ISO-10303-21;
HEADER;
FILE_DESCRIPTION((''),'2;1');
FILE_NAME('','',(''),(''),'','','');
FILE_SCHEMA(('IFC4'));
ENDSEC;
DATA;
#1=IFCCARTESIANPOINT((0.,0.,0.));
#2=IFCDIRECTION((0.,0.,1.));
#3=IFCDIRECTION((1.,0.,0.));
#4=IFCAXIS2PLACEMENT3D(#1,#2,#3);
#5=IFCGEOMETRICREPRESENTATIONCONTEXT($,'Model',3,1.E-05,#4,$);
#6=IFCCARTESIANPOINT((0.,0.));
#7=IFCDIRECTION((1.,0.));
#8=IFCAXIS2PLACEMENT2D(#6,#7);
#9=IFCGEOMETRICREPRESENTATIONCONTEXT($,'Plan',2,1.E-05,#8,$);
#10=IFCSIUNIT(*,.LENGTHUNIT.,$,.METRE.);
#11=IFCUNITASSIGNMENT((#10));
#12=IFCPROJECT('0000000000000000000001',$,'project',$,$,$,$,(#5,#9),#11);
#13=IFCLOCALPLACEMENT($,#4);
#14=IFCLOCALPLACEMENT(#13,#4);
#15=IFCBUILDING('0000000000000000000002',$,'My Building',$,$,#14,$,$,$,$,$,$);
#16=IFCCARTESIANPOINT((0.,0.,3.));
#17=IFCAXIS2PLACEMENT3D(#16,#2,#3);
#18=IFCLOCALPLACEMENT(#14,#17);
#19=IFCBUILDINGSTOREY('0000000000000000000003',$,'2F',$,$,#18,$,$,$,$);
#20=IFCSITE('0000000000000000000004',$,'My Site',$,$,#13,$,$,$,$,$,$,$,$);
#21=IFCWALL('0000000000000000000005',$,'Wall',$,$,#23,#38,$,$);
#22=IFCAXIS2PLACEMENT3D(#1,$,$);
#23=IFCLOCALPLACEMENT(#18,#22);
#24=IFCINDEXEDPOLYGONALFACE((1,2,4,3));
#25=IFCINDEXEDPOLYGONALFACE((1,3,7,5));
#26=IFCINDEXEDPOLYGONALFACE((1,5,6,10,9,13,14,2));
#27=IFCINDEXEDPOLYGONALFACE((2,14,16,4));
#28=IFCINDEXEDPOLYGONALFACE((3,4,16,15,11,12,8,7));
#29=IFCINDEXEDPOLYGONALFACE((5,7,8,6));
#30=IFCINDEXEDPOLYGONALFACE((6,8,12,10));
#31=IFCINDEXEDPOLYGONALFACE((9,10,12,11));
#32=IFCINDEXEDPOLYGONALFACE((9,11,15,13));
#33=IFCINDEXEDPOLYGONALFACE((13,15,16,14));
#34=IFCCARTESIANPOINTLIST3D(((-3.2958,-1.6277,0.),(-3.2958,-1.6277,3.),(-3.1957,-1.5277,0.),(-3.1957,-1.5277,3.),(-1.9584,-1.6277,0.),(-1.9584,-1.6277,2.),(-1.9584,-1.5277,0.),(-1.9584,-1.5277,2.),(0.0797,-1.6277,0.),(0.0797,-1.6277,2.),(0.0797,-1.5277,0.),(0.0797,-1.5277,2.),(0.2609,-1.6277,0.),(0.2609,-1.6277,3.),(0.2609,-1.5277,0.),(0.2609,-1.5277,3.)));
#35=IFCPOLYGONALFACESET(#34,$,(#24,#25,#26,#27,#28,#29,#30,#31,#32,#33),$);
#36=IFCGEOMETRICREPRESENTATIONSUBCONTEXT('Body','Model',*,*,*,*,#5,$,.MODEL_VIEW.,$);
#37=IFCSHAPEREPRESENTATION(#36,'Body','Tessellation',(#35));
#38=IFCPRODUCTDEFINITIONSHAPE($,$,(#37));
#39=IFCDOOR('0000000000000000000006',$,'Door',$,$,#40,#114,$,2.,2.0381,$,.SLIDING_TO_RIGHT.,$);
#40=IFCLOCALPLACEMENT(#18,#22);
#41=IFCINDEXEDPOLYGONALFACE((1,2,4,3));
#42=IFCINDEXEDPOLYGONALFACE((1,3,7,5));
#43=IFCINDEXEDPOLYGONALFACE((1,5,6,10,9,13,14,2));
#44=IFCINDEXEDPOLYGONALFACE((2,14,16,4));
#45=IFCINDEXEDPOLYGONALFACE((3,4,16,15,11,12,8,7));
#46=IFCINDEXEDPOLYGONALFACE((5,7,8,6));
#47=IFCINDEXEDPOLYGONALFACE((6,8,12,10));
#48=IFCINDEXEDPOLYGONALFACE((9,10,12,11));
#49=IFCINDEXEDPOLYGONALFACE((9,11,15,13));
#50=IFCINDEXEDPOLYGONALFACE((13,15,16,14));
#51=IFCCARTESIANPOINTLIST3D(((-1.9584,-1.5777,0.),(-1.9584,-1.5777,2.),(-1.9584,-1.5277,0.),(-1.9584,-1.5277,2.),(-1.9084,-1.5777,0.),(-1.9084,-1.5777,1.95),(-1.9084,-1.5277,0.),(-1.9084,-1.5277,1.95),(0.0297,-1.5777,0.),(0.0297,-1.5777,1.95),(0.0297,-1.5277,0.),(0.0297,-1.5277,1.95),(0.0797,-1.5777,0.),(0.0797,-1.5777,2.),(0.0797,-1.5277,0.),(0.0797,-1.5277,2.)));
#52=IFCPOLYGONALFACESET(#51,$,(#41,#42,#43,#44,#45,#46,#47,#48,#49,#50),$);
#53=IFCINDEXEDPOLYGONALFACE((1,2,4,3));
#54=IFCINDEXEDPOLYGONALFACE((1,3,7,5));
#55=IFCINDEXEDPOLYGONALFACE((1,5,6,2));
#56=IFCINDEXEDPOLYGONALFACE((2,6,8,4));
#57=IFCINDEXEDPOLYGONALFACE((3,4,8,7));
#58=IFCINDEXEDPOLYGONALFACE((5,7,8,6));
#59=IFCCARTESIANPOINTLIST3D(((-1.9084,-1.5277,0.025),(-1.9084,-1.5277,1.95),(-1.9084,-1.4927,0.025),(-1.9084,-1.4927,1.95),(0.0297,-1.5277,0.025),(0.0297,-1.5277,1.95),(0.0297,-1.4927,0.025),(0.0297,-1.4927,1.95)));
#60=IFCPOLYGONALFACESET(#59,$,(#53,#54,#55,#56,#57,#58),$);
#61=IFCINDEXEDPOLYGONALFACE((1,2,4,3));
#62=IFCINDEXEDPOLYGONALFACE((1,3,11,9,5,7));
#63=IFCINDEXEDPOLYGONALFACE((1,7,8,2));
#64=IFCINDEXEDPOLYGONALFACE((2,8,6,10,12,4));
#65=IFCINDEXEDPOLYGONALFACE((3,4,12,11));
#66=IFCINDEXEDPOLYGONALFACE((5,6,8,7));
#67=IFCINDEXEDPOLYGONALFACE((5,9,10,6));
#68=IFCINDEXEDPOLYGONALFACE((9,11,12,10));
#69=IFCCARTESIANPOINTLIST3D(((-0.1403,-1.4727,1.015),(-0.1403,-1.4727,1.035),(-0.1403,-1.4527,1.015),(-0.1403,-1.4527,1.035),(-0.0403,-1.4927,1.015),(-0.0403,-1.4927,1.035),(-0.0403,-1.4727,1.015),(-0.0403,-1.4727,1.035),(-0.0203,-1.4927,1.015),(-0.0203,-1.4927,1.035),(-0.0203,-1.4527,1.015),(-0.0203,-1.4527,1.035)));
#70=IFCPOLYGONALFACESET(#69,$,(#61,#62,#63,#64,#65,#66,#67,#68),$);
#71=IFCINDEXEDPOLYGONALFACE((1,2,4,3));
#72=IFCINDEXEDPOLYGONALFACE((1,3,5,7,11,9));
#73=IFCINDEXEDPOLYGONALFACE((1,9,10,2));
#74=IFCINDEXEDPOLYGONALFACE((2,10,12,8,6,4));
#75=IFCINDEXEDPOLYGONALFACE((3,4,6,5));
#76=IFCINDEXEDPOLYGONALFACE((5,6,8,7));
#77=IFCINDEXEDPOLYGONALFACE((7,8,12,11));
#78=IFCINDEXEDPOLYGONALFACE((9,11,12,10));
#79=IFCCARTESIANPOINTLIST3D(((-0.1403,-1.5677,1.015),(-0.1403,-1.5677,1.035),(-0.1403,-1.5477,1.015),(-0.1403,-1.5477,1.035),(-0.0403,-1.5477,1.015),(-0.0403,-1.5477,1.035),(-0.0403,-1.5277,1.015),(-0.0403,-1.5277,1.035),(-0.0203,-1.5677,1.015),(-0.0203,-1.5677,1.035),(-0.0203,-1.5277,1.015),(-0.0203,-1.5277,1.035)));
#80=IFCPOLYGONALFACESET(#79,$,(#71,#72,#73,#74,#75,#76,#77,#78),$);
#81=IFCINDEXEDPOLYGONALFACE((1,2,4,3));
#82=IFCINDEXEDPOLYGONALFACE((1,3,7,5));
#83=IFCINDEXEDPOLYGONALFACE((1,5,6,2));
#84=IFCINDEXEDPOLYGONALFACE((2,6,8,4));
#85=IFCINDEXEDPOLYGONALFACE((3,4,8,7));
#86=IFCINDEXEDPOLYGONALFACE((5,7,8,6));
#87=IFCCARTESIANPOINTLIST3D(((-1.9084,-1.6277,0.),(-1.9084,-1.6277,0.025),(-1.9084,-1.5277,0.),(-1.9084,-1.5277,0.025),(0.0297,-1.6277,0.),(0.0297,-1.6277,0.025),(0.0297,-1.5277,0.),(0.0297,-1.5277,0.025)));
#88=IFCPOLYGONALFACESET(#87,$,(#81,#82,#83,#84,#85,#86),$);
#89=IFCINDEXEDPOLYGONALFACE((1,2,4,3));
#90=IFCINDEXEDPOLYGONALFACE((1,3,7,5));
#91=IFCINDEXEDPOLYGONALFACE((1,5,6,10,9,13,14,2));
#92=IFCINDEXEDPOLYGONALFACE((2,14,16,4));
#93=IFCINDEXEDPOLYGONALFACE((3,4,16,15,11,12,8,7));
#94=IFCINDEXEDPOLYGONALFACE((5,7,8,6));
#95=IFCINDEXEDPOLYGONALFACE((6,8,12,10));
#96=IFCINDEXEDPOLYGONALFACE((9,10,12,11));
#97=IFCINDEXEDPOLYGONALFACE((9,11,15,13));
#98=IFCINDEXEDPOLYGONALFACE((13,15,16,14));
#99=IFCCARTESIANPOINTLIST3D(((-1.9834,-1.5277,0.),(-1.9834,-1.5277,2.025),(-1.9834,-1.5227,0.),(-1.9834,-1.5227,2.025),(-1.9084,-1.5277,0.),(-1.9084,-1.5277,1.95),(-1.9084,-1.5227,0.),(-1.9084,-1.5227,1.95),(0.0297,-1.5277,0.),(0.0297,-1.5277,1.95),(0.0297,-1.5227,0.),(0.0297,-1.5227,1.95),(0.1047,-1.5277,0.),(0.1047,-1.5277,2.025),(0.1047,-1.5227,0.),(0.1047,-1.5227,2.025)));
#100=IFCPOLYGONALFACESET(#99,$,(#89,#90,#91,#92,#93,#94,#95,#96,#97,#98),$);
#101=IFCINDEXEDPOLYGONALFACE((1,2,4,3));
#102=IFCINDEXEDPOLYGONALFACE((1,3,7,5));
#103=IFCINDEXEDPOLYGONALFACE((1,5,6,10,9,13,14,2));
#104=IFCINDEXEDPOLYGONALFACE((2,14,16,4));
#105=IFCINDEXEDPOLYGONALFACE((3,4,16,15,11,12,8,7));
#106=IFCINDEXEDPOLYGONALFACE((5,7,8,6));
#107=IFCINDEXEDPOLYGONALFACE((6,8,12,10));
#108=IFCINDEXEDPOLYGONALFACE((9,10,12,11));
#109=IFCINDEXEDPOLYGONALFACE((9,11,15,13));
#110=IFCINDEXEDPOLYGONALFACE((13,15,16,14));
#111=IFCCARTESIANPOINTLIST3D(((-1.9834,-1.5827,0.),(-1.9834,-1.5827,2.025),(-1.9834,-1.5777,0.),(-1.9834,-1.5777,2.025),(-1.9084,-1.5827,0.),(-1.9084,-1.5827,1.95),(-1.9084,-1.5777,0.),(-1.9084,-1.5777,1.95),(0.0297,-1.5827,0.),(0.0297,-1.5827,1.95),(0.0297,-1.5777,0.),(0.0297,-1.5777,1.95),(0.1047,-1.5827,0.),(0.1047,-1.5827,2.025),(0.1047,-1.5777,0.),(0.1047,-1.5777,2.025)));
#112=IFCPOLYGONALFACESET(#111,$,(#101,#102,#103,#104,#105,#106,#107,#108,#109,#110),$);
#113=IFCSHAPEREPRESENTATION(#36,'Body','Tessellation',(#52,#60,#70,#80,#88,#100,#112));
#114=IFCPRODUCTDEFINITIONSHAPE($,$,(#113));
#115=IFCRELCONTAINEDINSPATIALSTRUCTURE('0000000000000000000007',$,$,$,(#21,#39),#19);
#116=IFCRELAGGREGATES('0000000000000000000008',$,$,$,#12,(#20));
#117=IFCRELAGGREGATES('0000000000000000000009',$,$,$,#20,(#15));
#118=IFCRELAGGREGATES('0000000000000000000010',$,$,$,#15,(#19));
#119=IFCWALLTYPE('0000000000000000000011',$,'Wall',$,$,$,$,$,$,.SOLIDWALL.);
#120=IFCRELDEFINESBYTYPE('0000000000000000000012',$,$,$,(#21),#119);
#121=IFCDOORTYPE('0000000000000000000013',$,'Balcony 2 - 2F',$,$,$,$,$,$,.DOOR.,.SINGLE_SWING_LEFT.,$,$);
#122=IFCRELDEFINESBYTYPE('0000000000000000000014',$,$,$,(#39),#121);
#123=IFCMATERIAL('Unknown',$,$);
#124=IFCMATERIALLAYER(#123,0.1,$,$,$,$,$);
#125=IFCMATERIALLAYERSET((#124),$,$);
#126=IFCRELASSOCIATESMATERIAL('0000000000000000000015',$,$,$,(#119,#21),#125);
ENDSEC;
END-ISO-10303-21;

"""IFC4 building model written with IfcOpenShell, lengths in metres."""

from ifc_helpers import new_model, entity, si_unit, frame, origin_with_axes, origin_2d_with_axis, place, context, subcontext, project, spatial, line, indexed_curve, outline, extrude, shape, source, transform, mapped, material, layer, layer_set, layer_usage, type_object, type_shapes, element, fill, save


model = new_model("IFC4")

# Units and contexts
model_context = context("Model", 3, precision=1e-05, world=origin_with_axes())
plan_context = context("Plan", 2, precision=1e-05, world=origin_2d_with_axis())
body_context_1 = subcontext(model_context, "Body", "Model", "MODEL_VIEW")
body_context_2 = subcontext(plan_context, "Body", "Plan", "PLAN_VIEW")
ifc_project = project(units=[si_unit("LENGTHUNIT", "METRE")], contexts=[model_context, plan_context])

# Site, building, storey
site_placement = place(None, origin_with_axes())
site = spatial("IfcSite", under=ifc_project, at=site_placement, Name="My Site")
building_placement = place(site_placement, origin_with_axes())
building = spatial("IfcBuilding", under=site, at=building_placement, Name="My Building")
storey_placement = place(building_placement, frame((0.0, 0.0, 3.0), z_axis=(0.0, 0.0, 1.0), x_axis=(1.0, 0.0, 0.0)))
storey = spatial("IfcBuildingStorey", under=building, at=storey_placement, Name="2F")

# Shared definitions
ifc_material = material(Name="Unknown")

# Shared definitions
ifc_layer_1 = layer(ifc_material, 0.1)
ifc_layer_set_1 = layer_set([ifc_layer_1])
wall_type = type_object("IfcWallType", Name="Wall", PredefinedType="SOLIDWALL", material=ifc_layer_set_1)

# Wall, opening, door
ifc_layer_usage_1 = layer_usage(ifc_layer_set_1, "AXIS2", "POSITIVE", 0.0)
wall_1_placement = place(storey_placement, frame((-3.2958, -1.6277, 0.0), z_axis=(0.0, 0.0, 1.0), x_axis=(1.0, 0.0, 0.0)))
wall_1 = element("IfcWall", 1, at=wall_1_placement, inside=storey, type_object=wall_type, material=ifc_layer_usage_1, Name="Wall", context=body_context_1, shape_type="SweptSolid", body=[
    extrude(outline(indexed_curve([(0.0, 0.0), (0.1002, 0.1), (3.5568, 0.1), (3.5568, 0.0)], segments=[line(1, 2, 3, 4, 1)])), origin_with_axes(), (0.0, 0.0, 1.0), 3.0),
])
shared_shape_1 = source(origin_with_axes(), body_context_1, "Body", "SweptSolid", [
    extrude(outline(indexed_curve([(0.0, 0.0), (2.0381, 0.0), (2.0381, 2.0), (0.0, 2.0)], segments=[line(1, 2, 3, 4, 1)])), frame((0.0, -0.6, 0.0), z_axis=(0.0, -1.0, 0.0), x_axis=(1.0, 0.0, 0.0)), (0.0, 0.0, -1.0), 1.2),
])
opening_1_placement = place(wall_1_placement, frame((3.3755, 0.1, 0.0), z_axis=(0.0, 0.0, 1.0), x_axis=(-1.0, 0.0, 0.0)))
opening_1 = element("IfcOpeningElement", 2, at=opening_1_placement, cuts=wall_1, PredefinedType="OPENING", context=body_context_1, shape_type="MappedRepresentation", body=[
    mapped(shared_shape_1, transform((0.0, 0.0, 0.0), x_axis=(1.0, 0.0, 0.0), y_axis=(0.0, 1.0, 0.0), z_axis=(0.0, 0.0, 1.0), scale=1.0)),
])
door_type_1 = type_object("IfcDoorType", Name="Balcony 2 - 2F", OperationType="SINGLE_SWING_LEFT", PredefinedType="DOOR")
shared_shape_2 = source(origin_with_axes(), body_context_1, "Body", "SweptSolid", [
    extrude(outline(indexed_curve([(0.0, 0.0), (0.0, 2.0), (2.0381, 2.0), (2.0381, 0.0), (1.9881, 0.0), (1.9881, 1.95), (0.05, 1.95), (0.05, 0.0)], segments=[line(1, 2, 3, 4, 5, 6, 7, 8, 1)])), frame((0.0, 0.0, 0.0), z_axis=(0.0, -1.0, 0.0), x_axis=(1.0, 0.0, 0.0)), (0.0, 0.0, -1.0), 0.05),
    extrude(outline(indexed_curve([(0.0, 0.0), (1.9381, 0.0), (1.9381, 0.035), (0.0, 0.035)], segments=[line(1, 2, 3, 4, 1)])), frame((0.05, -0.035, 0.025), z_axis=(0.0, 0.0, 1.0), x_axis=(1.0, 0.0, 0.0)), (0.0, 0.0, 1.0), 1.925),
    extrude(outline(indexed_curve([(0.0, 0.0), (0.0, -0.04), (0.12, -0.04), (0.12, -0.02), (0.02, -0.02), (0.02, 0.0)], segments=[line(1, 2, 3, 4, 5, 6, 1)])), frame((0.1, -0.035, 1.015), z_axis=(0.0, 0.0, 1.0), x_axis=(1.0, 0.0, 0.0)), (0.0, 0.0, 1.0), 0.02),
    extrude(outline(indexed_curve([(0.0, 0.0), (0.0, 0.04), (0.12, 0.04), (0.12, 0.02), (0.02, 0.02), (0.02, 0.0)], segments=[line(1, 2, 3, 4, 5, 6, 1)])), frame((0.1, 0.0, 1.015), z_axis=(0.0, 0.0, 1.0), x_axis=(1.0, 0.0, 0.0)), (0.0, 0.0, 1.0), 0.02),
    extrude(outline(indexed_curve([(0.0, 0.0), (1.9381, 0.0), (1.9381, 0.1), (0.0, 0.1)], segments=[line(1, 2, 3, 4, 1)])), frame((0.05, 0.0, 0.0), z_axis=(0.0, 0.0, 1.0), x_axis=(1.0, 0.0, 0.0)), (0.0, 0.0, 1.0), 0.025),
    extrude(outline(indexed_curve([(0.0, 0.0), (0.0, 2.025), (2.0881, 2.025), (2.0881, 0.0), (2.0131, 0.0), (2.0131, 1.95), (0.075, 1.95), (0.075, 0.0)], segments=[line(1, 2, 3, 4, 5, 6, 7, 8, 1)])), frame((-0.025, -0.005, 0.0), z_axis=(0.0, -1.0, 0.0), x_axis=(1.0, 0.0, 0.0)), (0.0, 0.0, -1.0), 0.005),
    extrude(outline(indexed_curve([(0.0, 0.0), (0.0, 2.025), (2.0881, 2.025), (2.0881, 0.0), (2.0131, 0.0), (2.0131, 1.95), (0.075, 1.95), (0.075, 0.0)], segments=[line(1, 2, 3, 4, 5, 6, 7, 8, 1)])), frame((-0.025, 0.05, 0.0), z_axis=(0.0, -1.0, 0.0), x_axis=(1.0, 0.0, 0.0)), (0.0, 0.0, -1.0), 0.005),
])
shared_shape_3 = source(origin_with_axes(), body_context_2, "Body", "Curve2D", [
    entity("IfcIndexedPolyCurve", entity("IfcCartesianPointList2D", [[0.0, 0.0], [0.05, 0.0], [0.05, 0.05], [0.0, 0.05]]), [entity("IfcLineIndex", [1, 2, 3, 4, 1])]),
    entity("IfcIndexedPolyCurve", entity("IfcCartesianPointList2D", [[2.0381, 0.0], [1.9881, 0.0], [1.9881, 0.05], [2.0381, 0.05]]), [entity("IfcLineIndex", [1, 2, 3, 4, 1])]),
    entity("IfcIndexedPolyCurve", entity("IfcCartesianPointList2D", [[2.9571, -0.035], [1.019, -0.035], [1.019, 0.0], [2.9571, 0.0]]), [entity("IfcLineIndex", [1, 2, 3, 4, 1])]),
])
type_shapes(door_type_1, [shared_shape_2, shared_shape_3])
door_1_placement = place(opening_1_placement, origin_with_axes())
door_1 = element("IfcDoor", 3, at=door_1_placement, inside=storey, type_object=door_type_1, Name="Door", OperationType="SLIDING_TO_RIGHT", OverallHeight=2.0, OverallWidth=2.0381, shapes=[
    shape(body_context_1, "Body", "MappedRepresentation", [mapped(shared_shape_2, transform((0.0, 0.0, 0.0), x_axis=(1.0, 0.0, 0.0), y_axis=(0.0, 1.0, 0.0), z_axis=(0.0, 0.0, 1.0), scale=1.0))]),
    shape(body_context_2, "Body", "MappedRepresentation", [mapped(shared_shape_3, transform((0.0, 0.0, 0.0), x_axis=(1.0, 0.0, 0.0), y_axis=(0.0, 1.0, 0.0), z_axis=(0.0, 0.0, 1.0), scale=1.0))]),
])
fill(opening_1, door_1)

save(model, "model.ifc")
